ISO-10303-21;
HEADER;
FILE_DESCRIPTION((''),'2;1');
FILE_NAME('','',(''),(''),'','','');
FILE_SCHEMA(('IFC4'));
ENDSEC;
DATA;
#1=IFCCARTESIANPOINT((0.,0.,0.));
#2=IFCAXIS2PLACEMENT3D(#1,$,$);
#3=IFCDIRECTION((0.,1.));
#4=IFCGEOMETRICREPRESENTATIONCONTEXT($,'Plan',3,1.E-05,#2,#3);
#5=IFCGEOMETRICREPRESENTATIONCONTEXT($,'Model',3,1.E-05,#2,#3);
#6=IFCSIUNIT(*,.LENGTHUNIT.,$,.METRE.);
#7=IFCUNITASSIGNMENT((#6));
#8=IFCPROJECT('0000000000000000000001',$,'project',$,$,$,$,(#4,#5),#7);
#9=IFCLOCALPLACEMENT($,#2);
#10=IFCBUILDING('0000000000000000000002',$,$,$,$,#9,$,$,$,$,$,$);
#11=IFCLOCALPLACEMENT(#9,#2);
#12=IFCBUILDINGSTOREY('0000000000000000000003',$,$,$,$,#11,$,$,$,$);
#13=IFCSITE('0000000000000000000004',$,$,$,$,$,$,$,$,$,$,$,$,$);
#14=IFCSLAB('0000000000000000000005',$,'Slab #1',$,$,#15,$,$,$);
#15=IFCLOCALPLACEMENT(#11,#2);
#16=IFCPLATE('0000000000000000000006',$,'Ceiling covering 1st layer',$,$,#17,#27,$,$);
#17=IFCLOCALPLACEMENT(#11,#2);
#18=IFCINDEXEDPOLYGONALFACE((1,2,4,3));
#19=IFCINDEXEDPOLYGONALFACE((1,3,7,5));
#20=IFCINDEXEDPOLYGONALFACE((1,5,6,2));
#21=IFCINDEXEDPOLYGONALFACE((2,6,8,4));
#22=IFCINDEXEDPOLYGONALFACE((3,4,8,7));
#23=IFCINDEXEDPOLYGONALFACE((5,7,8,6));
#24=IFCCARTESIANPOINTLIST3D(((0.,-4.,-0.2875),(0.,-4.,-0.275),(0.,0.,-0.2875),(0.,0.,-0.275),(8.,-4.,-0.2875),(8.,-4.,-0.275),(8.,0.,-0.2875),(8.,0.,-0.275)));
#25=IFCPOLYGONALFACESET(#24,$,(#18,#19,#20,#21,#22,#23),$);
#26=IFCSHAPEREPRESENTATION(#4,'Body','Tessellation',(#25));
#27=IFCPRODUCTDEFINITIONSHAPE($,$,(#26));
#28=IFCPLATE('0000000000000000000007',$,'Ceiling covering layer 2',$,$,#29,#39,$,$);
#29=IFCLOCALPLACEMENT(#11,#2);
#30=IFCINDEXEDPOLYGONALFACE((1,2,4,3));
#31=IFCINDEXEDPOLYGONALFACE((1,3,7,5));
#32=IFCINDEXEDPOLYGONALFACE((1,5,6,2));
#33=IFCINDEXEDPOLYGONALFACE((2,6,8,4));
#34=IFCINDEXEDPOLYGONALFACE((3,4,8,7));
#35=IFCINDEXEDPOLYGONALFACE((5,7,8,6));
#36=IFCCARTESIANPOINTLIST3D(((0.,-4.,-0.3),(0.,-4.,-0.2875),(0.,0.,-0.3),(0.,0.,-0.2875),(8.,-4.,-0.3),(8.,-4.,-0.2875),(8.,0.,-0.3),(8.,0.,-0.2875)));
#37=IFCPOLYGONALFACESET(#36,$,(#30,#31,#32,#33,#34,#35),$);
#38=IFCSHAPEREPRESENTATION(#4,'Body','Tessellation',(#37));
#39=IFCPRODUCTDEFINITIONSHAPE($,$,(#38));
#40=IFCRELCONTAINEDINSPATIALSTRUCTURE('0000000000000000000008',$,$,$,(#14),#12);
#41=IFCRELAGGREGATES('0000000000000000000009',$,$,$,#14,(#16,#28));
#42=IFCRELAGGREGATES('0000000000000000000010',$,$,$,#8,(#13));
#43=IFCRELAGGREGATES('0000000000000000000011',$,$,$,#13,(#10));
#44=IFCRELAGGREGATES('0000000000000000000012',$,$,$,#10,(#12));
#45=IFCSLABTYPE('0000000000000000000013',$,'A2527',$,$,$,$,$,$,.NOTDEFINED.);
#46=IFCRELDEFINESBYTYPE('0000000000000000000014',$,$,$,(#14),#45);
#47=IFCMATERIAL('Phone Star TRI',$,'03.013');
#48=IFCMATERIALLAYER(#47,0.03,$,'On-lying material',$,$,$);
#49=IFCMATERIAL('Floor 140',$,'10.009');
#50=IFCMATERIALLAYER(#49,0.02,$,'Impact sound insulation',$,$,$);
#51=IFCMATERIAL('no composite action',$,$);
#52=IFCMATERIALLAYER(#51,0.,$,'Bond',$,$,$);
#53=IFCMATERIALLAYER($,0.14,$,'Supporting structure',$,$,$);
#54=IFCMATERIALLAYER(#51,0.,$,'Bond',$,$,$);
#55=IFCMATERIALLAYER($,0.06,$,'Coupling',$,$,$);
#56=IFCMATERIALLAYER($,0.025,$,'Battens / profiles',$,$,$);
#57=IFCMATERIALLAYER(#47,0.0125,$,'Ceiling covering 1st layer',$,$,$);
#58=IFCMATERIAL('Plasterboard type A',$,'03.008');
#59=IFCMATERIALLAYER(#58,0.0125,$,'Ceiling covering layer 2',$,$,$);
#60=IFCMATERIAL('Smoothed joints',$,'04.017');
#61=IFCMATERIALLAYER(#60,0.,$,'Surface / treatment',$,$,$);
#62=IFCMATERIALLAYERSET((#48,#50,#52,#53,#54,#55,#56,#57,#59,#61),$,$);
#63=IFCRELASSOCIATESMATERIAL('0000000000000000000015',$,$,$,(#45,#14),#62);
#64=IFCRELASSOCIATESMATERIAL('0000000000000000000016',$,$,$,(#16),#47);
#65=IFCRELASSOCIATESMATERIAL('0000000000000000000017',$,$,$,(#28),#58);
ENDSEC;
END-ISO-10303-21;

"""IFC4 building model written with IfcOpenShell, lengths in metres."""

from ifc_helpers import new_model, si_unit, direction, frame, frame_2d, origin, place, context, project, spatial, rectangle, extrude, material, layer, layer_set, type_object, element, aggregate, save


model = new_model("IFC4")

# Units and contexts
plan_context = context("Plan", 3, precision=1e-05, world=origin(), true_north=direction((0.0, 1.0)))
model_context = context("Model", 3, precision=1e-05, world=origin(), true_north=direction((0.0, 1.0)))
ifc_project = project(units=[si_unit("LENGTHUNIT", "METRE")], contexts=[plan_context, model_context])

# Site, building, storey
site = spatial("IfcSite", under=ifc_project)
building_placement = place(None, origin())
building = spatial("IfcBuilding", under=site, at=building_placement)
storey_placement = place(building_placement, origin())
storey = spatial("IfcBuildingStorey", under=building, at=storey_placement)

# Slab, plates
ifc_material_1 = material(Name="Phone Star TRI", Category="03.013")
ifc_layer_1 = layer(ifc_material_1, 0.03, Name="On-lying material")
ifc_material_2 = material(Name="Floor 140", Category="10.009")
ifc_layer_2 = layer(ifc_material_2, 0.02, Name="Impact sound insulation")
ifc_material_3 = material(Name="no composite action")
ifc_layer_3 = layer(ifc_material_3, 0.0, Name="Bond")
ifc_layer_4 = layer(None, 0.14, Name="Supporting structure")
ifc_layer_5 = layer(ifc_material_3, 0.0, Name="Bond")
ifc_layer_6 = layer(None, 0.06, Name="Coupling")
ifc_layer_7 = layer(None, 0.025, Name="Battens / profiles")
ifc_layer_8 = layer(ifc_material_1, 0.0125, Name="Ceiling covering 1st layer")
ifc_material_4 = material(Name="Plasterboard type A", Category="03.008")
ifc_layer_9 = layer(ifc_material_4, 0.0125, Name="Ceiling covering layer 2")
ifc_material_5 = material(Name="Smoothed joints", Category="04.017")
ifc_layer_10 = layer(ifc_material_5, 0.0, Name="Surface / treatment")
ifc_layer_set = layer_set([ifc_layer_1, ifc_layer_2, ifc_layer_3, ifc_layer_4, ifc_layer_5, ifc_layer_6, ifc_layer_7, ifc_layer_8, ifc_layer_9, ifc_layer_10])
slab_type = type_object("IfcSlabType", Name="A2527", PredefinedType="NOTDEFINED", material=ifc_layer_set)
slab_placement = place(None, frame((0.0, 0.0, 0.0), z_axis=(0.0, 0.0, -1.0), x_axis=(1.0, 0.0, 0.0)))
slab = element("IfcSlab", 1, at=slab_placement, inside=storey, type_object=slab_type, material=ifc_layer_set, Name="Slab #1")
plate_1_placement = place(slab_placement, origin())
plate_1 = element("IfcPlate", 2, at=plate_1_placement, material=ifc_material_1, Name="Ceiling covering 1st layer", context=plan_context, shape_type="SweptSolid", body=[
    extrude(rectangle(XDim=8.0, YDim=4.0, at=frame_2d((4.0, 2.0), x_axis=(1.0, 0.0))), frame((0.0, 0.0, 0.275), z_axis=(0.0, 0.0, 1.0), x_axis=(1.0, 0.0, 0.0)), (0.0, 0.0, 1.0), 0.0125),
])
plate_2_placement = place(slab_placement, origin())
plate_2 = element("IfcPlate", 3, at=plate_2_placement, material=ifc_material_4, Name="Ceiling covering layer 2", context=plan_context, shape_type="SweptSolid", body=[
    extrude(rectangle(XDim=8.0, YDim=4.0, at=frame_2d((4.0, 2.0), x_axis=(1.0, 0.0))), frame((0.0, 0.0, 0.2875), z_axis=(0.0, 0.0, 1.0), x_axis=(1.0, 0.0, 0.0)), (0.0, 0.0, 1.0), 0.0125),
])
aggregate(slab, [plate_1, plate_2])

save(model, "model.ifc")
